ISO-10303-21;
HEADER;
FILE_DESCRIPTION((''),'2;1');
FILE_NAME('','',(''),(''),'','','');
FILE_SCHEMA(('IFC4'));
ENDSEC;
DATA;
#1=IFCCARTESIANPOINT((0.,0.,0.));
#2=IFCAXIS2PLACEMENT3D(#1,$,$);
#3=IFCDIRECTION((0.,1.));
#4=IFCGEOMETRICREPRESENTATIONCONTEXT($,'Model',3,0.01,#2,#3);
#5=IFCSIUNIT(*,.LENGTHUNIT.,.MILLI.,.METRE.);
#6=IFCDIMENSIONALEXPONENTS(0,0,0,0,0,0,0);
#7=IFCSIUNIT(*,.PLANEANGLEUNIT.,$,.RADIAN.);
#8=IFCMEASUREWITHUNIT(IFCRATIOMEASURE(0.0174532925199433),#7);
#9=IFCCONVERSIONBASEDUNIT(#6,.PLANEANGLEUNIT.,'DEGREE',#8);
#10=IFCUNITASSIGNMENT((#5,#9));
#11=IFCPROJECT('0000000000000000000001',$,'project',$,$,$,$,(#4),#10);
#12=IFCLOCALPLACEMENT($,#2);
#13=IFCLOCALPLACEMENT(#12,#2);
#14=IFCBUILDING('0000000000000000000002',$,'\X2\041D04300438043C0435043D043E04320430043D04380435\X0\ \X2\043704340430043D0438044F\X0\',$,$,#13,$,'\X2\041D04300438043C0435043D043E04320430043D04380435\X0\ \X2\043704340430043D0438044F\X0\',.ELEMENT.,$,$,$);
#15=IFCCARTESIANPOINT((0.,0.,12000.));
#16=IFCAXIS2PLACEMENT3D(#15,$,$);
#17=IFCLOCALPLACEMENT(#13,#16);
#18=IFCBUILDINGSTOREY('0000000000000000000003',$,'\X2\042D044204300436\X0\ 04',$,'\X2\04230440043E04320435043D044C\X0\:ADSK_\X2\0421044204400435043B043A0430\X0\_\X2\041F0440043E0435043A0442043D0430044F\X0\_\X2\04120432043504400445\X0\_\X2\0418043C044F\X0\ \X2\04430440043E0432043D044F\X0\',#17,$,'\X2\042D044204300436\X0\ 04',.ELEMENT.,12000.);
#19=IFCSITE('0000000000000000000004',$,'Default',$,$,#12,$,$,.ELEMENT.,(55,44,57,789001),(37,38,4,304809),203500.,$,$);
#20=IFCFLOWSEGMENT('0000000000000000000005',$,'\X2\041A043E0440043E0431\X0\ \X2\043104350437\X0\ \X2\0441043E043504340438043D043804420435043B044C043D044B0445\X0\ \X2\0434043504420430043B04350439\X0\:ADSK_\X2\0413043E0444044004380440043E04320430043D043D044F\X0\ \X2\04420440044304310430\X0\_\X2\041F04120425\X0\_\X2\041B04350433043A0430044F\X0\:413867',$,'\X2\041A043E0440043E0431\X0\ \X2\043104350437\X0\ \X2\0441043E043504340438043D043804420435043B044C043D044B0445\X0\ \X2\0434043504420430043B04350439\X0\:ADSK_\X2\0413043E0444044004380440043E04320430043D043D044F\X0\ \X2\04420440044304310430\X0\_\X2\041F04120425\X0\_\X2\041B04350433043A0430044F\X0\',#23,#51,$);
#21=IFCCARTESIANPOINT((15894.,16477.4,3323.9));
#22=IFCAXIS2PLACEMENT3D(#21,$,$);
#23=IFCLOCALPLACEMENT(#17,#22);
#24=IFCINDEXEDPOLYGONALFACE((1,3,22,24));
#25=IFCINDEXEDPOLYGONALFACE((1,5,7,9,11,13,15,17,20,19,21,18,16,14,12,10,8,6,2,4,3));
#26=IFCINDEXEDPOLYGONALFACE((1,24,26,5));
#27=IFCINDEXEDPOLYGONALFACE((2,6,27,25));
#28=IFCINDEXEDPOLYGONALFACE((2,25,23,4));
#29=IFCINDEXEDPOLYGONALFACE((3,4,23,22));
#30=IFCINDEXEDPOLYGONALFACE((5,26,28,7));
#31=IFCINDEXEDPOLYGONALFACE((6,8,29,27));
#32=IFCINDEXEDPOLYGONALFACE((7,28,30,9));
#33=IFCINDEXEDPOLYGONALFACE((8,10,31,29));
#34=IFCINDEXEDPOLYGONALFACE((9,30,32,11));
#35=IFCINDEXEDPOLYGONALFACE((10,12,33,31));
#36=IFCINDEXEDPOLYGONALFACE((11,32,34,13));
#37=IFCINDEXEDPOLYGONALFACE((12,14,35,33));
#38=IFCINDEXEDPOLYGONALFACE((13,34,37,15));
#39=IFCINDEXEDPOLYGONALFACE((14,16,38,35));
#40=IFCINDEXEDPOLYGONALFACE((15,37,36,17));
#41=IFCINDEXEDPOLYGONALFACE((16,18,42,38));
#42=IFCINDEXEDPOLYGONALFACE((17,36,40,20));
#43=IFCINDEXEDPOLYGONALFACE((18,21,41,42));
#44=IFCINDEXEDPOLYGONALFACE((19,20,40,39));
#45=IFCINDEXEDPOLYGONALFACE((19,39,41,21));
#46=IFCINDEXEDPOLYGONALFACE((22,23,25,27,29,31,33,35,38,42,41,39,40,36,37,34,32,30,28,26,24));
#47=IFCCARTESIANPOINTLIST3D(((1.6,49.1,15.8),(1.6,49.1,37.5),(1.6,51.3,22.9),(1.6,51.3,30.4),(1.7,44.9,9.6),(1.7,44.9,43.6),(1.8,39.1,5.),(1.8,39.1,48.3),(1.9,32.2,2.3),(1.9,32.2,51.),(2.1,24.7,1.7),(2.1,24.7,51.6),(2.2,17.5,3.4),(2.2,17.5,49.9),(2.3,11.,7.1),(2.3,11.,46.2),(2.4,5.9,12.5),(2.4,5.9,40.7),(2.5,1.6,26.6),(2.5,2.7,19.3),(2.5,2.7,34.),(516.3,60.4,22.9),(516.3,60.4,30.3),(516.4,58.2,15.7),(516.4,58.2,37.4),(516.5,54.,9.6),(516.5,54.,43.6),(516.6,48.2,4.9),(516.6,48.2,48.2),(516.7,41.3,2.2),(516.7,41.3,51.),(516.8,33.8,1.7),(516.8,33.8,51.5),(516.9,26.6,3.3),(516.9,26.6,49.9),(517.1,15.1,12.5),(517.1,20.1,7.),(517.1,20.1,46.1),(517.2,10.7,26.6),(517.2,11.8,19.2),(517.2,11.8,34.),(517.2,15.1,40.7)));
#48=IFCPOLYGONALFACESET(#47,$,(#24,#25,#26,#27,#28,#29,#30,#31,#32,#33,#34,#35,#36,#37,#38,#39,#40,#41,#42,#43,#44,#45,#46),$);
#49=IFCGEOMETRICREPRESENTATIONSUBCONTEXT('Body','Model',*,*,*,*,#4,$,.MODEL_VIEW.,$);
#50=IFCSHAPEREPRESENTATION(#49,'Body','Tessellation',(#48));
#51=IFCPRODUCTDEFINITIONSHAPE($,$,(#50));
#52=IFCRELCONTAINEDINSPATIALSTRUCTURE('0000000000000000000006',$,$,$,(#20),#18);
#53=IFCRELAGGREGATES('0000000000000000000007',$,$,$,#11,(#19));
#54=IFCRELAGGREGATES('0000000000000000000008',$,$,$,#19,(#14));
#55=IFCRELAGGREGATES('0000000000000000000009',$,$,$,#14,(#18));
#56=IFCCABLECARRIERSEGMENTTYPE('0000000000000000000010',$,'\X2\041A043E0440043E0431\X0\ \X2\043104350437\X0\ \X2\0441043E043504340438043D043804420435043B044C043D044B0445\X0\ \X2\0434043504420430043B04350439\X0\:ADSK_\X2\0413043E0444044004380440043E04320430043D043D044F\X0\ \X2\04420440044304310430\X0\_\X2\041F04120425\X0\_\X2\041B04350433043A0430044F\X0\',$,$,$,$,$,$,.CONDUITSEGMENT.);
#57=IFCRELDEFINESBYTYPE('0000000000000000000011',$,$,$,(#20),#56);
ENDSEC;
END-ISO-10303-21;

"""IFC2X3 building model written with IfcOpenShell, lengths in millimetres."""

from ifc_helpers import new_model, entity, si_unit, converted_unit, direction, frame, frame_2d, origin, place, context, subcontext, project, spatial, circle, extrude, type_object, element, save


model = new_model("IFC2X3")

# Units and contexts
model_context = context("Model", 3, precision=0.01, world=origin(), true_north=direction((0.0, 1.0)))
body_context = subcontext(model_context, "Body", "Model", "MODEL_VIEW")
ifc_project = project(units=[si_unit("LENGTHUNIT", "METRE", prefix="MILLI"), converted_unit("PLANEANGLEUNIT", "DEGREE", entity("IfcRatioMeasure", 0.0174532925199433), si_unit("PLANEANGLEUNIT", "RADIAN"), dimensions=[0, 0, 0, 0, 0, 0, 0])], contexts=[model_context])

# Site, building, storey
site_placement = place(None, frame((0.0, 0.0, 0.0)))
site = spatial("IfcSite", under=ifc_project, at=site_placement, Name="Default", CompositionType="ELEMENT", RefLatitude=(55, 44, 57, 789001), RefLongitude=(37, 38, 4, 304809), RefElevation=203500.0)
building_placement = place(site_placement, origin())
building = spatial("IfcBuilding", under=site, at=building_placement, Name="Наименование здания", LongName="Наименование здания", CompositionType="ELEMENT")
storey_placement = place(building_placement, frame((0.0, 0.0, 12000.0)))
storey = spatial("IfcBuildingStorey", under=building, at=storey_placement, Name="Этаж 04", ObjectType="Уровень:ADSK_Стрелка_Проектная_Вверх_Имя уровня", LongName="Этаж 04", CompositionType="ELEMENT", Elevation=12000.0)

# Flow segment
cable_carrier_segment_type = type_object("IfcCableCarrierSegmentType", Name="Короб без соединительных деталей:ADSK_Гофрировання труба_ПВХ_Легкая", PredefinedType="CONDUITSEGMENT")
flow_segment_1_placement = place(storey_placement, frame((15894.0, 16477.4, 3323.9)))
element("IfcFlowSegment", 1, at=flow_segment_1_placement, inside=storey, type_object=cable_carrier_segment_type, Name="Короб без соединительных деталей:ADSK_Гофрировання труба_ПВХ_Легкая:413867", ObjectType="Короб без соединительных деталей:ADSK_Гофрировання труба_ПВХ_Легкая", context=body_context, shape_type="SweptSolid", body=[
    extrude(circle(Radius=25.0, at=frame_2d((0.0, 0.0), x_axis=(1.0, 0.0))), frame((516.8, 35.7, 26.6), z_axis=(-0.999843, -0.017709, 0.000064), x_axis=(0.017709, -0.999843, 0.0)), (0.0, 0.0, 1.0), 514.8),
])

save(model, "model.ifc")
